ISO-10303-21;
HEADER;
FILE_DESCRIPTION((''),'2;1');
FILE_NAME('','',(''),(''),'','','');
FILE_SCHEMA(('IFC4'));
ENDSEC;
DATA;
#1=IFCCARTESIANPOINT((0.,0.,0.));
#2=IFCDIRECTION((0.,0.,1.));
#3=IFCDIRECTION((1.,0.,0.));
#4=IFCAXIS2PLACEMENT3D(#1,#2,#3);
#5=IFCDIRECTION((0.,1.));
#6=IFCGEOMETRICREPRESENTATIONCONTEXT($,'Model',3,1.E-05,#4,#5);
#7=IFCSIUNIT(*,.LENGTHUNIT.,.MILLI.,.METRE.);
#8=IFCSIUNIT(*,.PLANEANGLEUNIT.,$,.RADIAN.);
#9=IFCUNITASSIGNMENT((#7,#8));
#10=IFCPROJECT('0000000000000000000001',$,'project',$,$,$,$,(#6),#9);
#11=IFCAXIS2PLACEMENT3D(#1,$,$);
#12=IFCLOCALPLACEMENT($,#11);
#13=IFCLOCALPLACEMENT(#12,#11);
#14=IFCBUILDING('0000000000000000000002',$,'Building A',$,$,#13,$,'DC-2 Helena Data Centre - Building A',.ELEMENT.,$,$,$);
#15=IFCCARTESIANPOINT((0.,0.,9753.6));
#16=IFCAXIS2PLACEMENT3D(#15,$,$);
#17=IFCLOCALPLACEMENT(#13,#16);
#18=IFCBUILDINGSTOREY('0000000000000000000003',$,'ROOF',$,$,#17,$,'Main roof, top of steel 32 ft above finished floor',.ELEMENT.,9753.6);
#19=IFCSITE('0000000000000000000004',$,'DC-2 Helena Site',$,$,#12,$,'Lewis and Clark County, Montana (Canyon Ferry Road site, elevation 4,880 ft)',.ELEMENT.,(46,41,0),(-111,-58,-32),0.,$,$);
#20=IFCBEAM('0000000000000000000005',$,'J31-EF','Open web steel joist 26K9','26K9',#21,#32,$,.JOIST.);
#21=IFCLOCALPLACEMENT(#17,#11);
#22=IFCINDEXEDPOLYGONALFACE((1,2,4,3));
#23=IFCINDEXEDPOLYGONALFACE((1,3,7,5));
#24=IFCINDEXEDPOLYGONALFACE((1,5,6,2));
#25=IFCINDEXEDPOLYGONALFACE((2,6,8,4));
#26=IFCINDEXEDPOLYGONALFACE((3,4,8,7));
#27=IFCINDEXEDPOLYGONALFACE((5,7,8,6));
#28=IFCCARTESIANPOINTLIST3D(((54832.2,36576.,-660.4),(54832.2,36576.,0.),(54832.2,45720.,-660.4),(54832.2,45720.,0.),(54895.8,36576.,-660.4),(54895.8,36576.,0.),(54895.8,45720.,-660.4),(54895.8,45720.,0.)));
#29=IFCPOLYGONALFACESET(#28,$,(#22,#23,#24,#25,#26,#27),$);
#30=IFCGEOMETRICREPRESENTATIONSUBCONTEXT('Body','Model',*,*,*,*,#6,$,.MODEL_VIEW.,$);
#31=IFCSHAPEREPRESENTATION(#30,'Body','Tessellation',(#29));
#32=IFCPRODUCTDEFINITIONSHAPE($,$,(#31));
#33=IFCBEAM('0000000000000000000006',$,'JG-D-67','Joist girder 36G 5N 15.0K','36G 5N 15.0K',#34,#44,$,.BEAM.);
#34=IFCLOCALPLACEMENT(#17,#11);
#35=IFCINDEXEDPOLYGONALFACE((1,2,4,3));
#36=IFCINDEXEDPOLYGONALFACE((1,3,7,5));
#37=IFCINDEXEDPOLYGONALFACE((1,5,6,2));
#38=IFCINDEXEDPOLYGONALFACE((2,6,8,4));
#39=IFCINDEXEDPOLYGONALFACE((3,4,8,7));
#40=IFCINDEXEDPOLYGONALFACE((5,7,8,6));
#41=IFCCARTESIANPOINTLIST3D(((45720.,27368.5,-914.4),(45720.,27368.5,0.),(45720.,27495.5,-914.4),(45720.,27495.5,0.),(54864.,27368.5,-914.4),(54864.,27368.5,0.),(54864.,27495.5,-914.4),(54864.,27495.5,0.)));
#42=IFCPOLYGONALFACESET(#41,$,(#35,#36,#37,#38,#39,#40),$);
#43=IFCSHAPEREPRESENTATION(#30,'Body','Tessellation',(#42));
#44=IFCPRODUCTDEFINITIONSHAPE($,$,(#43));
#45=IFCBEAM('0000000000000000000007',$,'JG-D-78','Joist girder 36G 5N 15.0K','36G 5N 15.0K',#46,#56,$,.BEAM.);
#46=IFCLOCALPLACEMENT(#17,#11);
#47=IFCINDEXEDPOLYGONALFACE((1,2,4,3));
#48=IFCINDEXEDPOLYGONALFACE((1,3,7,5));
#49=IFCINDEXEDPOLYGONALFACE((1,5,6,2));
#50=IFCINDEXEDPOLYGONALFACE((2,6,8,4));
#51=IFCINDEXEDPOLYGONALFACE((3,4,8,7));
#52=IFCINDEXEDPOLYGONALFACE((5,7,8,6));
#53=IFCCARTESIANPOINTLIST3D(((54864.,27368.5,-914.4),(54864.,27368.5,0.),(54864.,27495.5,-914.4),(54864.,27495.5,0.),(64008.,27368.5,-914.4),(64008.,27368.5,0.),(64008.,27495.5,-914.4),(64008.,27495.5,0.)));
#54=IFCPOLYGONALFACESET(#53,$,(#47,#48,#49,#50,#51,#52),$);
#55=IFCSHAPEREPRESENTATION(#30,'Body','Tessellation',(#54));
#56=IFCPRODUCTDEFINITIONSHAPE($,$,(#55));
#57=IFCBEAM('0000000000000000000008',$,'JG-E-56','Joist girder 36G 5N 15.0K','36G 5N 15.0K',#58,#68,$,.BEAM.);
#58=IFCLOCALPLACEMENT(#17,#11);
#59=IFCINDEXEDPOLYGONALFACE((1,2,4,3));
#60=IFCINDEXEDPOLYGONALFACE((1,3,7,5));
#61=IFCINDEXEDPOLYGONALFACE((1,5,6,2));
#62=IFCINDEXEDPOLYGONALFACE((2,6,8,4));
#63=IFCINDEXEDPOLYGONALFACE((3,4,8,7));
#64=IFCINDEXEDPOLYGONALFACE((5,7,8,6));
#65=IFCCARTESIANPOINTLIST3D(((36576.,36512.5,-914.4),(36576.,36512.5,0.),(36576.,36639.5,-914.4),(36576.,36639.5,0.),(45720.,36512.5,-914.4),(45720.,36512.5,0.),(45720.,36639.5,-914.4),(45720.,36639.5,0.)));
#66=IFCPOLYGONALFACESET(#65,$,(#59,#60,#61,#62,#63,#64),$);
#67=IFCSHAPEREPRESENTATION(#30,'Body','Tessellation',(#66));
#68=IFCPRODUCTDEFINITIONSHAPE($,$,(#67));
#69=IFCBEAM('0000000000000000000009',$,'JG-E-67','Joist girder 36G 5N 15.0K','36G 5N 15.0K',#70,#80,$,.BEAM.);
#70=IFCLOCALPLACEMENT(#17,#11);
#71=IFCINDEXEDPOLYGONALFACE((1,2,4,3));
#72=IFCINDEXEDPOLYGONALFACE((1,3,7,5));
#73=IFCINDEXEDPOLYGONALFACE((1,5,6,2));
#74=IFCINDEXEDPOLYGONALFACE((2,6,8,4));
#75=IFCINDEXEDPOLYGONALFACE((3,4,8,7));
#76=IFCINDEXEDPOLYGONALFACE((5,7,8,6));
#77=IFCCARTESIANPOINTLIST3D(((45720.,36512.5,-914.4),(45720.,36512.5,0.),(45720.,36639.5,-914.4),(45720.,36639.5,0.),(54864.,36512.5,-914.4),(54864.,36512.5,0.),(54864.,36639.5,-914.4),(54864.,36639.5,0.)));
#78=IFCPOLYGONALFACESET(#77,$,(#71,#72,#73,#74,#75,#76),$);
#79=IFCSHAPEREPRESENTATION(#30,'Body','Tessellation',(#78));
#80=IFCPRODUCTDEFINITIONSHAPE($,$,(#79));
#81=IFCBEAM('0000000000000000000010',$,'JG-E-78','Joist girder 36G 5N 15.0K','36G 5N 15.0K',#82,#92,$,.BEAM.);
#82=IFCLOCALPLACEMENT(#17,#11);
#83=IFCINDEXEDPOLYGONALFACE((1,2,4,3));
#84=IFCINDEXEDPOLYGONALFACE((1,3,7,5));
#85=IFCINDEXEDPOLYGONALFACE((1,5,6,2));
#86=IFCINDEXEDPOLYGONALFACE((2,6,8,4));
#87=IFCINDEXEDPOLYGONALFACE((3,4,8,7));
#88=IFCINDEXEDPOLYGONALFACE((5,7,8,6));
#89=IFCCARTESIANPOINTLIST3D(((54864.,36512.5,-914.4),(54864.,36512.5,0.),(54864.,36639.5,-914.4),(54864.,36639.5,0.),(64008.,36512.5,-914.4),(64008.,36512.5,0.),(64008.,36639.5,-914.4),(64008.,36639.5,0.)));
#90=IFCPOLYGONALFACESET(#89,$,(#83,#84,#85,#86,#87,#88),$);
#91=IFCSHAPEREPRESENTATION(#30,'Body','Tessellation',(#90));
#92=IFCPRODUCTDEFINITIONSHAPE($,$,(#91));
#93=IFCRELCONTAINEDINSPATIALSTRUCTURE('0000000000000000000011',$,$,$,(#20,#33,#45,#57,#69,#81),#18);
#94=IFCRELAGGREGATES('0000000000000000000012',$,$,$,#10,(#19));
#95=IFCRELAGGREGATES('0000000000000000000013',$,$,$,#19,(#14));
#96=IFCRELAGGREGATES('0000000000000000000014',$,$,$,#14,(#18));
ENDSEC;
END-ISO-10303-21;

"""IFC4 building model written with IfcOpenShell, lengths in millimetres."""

from ifc_helpers import new_model, si_unit, direction, frame, origin, origin_with_axes, origin_2d, place, context, subcontext, project, spatial, rectangle, extrude, element, save


model = new_model("IFC4")

# Units and contexts
model_context = context("Model", 3, precision=1e-05, world=origin_with_axes(), true_north=direction((0.0, 1.0)))
body_context = subcontext(model_context, "Body", "Model", "MODEL_VIEW")
ifc_project = project(units=[si_unit("LENGTHUNIT", "METRE", prefix="MILLI"), si_unit("PLANEANGLEUNIT", "RADIAN")], contexts=[model_context])

# Site, building, storey
site_placement = place(None, origin())
site = spatial("IfcSite", under=ifc_project, at=site_placement, Name="DC-2 Helena Site", LongName="Lewis and Clark County, Montana (Canyon Ferry Road site, elevation 4,880 ft)", CompositionType="ELEMENT", RefLatitude=(46, 41, 0), RefLongitude=(-111, -58, -32), RefElevation=0.0)
building_placement = place(site_placement, origin())
building = spatial("IfcBuilding", under=site, at=building_placement, Name="Building A", LongName="DC-2 Helena Data Centre - Building A", CompositionType="ELEMENT")
storey_placement = place(building_placement, frame((0.0, 0.0, 9753.6)))
storey = spatial("IfcBuildingStorey", under=building, at=storey_placement, Name="ROOF", LongName="Main roof, top of steel 32 ft above finished floor", CompositionType="ELEMENT", Elevation=9753.6)

# Beams
placement_1 = place(storey_placement, frame((45720.0, 27432.0, 0.0)))
placement_2 = place(storey_placement, frame((45720.0, 36576.0, 0.0)))
placement_3 = place(storey_placement, frame((54864.0, 27432.0, 0.0)))
placement_4 = place(storey_placement, frame((54864.0, 36576.0, 0.0)))
element("IfcBeam", 1, at=placement_4, inside=storey, Name="J31-EF", Description="Open web steel joist 26K9", ObjectType="26K9", PredefinedType="JOIST", context=body_context, shape_type="SweptSolid", body=[
    extrude(rectangle(XDim=63.5, YDim=660.4, at=origin_2d()), frame((0.0, 0.0, -330.2), z_axis=(0.0, 1.0, 0.0), x_axis=(1.0, 0.0, 0.0)), (0.0, 0.0, 1.0), 9144.0),
])
element("IfcBeam", 2, at=placement_1, inside=storey, Name="JG-D-67", Description="Joist girder 36G 5N 15.0K", ObjectType="36G 5N 15.0K", PredefinedType="BEAM", context=body_context, shape_type="SweptSolid", body=[
    extrude(rectangle(XDim=127.0, YDim=914.4, at=origin_2d()), frame((0.0, 0.0, -457.2), z_axis=(1.0, 0.0, 0.0), x_axis=(0.0, 1.0, 0.0)), (0.0, 0.0, 1.0), 9144.0),
])
element("IfcBeam", 3, at=placement_3, inside=storey, Name="JG-D-78", Description="Joist girder 36G 5N 15.0K", ObjectType="36G 5N 15.0K", PredefinedType="BEAM", context=body_context, shape_type="SweptSolid", body=[
    extrude(rectangle(XDim=127.0, YDim=914.4, at=origin_2d()), frame((0.0, 0.0, -457.2), z_axis=(1.0, 0.0, 0.0), x_axis=(0.0, 1.0, 0.0)), (0.0, 0.0, 1.0), 9144.0),
])
beam_1_placement = place(storey_placement, frame((36576.0, 36576.0, 0.0)))
element("IfcBeam", 4, at=beam_1_placement, inside=storey, Name="JG-E-56", Description="Joist girder 36G 5N 15.0K", ObjectType="36G 5N 15.0K", PredefinedType="BEAM", context=body_context, shape_type="SweptSolid", body=[
    extrude(rectangle(XDim=127.0, YDim=914.4, at=origin_2d()), frame((0.0, 0.0, -457.2), z_axis=(1.0, 0.0, 0.0), x_axis=(0.0, 1.0, 0.0)), (0.0, 0.0, 1.0), 9144.0),
])
element("IfcBeam", 5, at=placement_2, inside=storey, Name="JG-E-67", Description="Joist girder 36G 5N 15.0K", ObjectType="36G 5N 15.0K", PredefinedType="BEAM", context=body_context, shape_type="SweptSolid", body=[
    extrude(rectangle(XDim=127.0, YDim=914.4, at=origin_2d()), frame((0.0, 0.0, -457.2), z_axis=(1.0, 0.0, 0.0), x_axis=(0.0, 1.0, 0.0)), (0.0, 0.0, 1.0), 9144.0),
])
element("IfcBeam", 6, at=placement_4, inside=storey, Name="JG-E-78", Description="Joist girder 36G 5N 15.0K", ObjectType="36G 5N 15.0K", PredefinedType="BEAM", context=body_context, shape_type="SweptSolid", body=[
    extrude(rectangle(XDim=127.0, YDim=914.4, at=origin_2d()), frame((0.0, 0.0, -457.2), z_axis=(1.0, 0.0, 0.0), x_axis=(0.0, 1.0, 0.0)), (0.0, 0.0, 1.0), 9144.0),
])

save(model, "model.ifc")
